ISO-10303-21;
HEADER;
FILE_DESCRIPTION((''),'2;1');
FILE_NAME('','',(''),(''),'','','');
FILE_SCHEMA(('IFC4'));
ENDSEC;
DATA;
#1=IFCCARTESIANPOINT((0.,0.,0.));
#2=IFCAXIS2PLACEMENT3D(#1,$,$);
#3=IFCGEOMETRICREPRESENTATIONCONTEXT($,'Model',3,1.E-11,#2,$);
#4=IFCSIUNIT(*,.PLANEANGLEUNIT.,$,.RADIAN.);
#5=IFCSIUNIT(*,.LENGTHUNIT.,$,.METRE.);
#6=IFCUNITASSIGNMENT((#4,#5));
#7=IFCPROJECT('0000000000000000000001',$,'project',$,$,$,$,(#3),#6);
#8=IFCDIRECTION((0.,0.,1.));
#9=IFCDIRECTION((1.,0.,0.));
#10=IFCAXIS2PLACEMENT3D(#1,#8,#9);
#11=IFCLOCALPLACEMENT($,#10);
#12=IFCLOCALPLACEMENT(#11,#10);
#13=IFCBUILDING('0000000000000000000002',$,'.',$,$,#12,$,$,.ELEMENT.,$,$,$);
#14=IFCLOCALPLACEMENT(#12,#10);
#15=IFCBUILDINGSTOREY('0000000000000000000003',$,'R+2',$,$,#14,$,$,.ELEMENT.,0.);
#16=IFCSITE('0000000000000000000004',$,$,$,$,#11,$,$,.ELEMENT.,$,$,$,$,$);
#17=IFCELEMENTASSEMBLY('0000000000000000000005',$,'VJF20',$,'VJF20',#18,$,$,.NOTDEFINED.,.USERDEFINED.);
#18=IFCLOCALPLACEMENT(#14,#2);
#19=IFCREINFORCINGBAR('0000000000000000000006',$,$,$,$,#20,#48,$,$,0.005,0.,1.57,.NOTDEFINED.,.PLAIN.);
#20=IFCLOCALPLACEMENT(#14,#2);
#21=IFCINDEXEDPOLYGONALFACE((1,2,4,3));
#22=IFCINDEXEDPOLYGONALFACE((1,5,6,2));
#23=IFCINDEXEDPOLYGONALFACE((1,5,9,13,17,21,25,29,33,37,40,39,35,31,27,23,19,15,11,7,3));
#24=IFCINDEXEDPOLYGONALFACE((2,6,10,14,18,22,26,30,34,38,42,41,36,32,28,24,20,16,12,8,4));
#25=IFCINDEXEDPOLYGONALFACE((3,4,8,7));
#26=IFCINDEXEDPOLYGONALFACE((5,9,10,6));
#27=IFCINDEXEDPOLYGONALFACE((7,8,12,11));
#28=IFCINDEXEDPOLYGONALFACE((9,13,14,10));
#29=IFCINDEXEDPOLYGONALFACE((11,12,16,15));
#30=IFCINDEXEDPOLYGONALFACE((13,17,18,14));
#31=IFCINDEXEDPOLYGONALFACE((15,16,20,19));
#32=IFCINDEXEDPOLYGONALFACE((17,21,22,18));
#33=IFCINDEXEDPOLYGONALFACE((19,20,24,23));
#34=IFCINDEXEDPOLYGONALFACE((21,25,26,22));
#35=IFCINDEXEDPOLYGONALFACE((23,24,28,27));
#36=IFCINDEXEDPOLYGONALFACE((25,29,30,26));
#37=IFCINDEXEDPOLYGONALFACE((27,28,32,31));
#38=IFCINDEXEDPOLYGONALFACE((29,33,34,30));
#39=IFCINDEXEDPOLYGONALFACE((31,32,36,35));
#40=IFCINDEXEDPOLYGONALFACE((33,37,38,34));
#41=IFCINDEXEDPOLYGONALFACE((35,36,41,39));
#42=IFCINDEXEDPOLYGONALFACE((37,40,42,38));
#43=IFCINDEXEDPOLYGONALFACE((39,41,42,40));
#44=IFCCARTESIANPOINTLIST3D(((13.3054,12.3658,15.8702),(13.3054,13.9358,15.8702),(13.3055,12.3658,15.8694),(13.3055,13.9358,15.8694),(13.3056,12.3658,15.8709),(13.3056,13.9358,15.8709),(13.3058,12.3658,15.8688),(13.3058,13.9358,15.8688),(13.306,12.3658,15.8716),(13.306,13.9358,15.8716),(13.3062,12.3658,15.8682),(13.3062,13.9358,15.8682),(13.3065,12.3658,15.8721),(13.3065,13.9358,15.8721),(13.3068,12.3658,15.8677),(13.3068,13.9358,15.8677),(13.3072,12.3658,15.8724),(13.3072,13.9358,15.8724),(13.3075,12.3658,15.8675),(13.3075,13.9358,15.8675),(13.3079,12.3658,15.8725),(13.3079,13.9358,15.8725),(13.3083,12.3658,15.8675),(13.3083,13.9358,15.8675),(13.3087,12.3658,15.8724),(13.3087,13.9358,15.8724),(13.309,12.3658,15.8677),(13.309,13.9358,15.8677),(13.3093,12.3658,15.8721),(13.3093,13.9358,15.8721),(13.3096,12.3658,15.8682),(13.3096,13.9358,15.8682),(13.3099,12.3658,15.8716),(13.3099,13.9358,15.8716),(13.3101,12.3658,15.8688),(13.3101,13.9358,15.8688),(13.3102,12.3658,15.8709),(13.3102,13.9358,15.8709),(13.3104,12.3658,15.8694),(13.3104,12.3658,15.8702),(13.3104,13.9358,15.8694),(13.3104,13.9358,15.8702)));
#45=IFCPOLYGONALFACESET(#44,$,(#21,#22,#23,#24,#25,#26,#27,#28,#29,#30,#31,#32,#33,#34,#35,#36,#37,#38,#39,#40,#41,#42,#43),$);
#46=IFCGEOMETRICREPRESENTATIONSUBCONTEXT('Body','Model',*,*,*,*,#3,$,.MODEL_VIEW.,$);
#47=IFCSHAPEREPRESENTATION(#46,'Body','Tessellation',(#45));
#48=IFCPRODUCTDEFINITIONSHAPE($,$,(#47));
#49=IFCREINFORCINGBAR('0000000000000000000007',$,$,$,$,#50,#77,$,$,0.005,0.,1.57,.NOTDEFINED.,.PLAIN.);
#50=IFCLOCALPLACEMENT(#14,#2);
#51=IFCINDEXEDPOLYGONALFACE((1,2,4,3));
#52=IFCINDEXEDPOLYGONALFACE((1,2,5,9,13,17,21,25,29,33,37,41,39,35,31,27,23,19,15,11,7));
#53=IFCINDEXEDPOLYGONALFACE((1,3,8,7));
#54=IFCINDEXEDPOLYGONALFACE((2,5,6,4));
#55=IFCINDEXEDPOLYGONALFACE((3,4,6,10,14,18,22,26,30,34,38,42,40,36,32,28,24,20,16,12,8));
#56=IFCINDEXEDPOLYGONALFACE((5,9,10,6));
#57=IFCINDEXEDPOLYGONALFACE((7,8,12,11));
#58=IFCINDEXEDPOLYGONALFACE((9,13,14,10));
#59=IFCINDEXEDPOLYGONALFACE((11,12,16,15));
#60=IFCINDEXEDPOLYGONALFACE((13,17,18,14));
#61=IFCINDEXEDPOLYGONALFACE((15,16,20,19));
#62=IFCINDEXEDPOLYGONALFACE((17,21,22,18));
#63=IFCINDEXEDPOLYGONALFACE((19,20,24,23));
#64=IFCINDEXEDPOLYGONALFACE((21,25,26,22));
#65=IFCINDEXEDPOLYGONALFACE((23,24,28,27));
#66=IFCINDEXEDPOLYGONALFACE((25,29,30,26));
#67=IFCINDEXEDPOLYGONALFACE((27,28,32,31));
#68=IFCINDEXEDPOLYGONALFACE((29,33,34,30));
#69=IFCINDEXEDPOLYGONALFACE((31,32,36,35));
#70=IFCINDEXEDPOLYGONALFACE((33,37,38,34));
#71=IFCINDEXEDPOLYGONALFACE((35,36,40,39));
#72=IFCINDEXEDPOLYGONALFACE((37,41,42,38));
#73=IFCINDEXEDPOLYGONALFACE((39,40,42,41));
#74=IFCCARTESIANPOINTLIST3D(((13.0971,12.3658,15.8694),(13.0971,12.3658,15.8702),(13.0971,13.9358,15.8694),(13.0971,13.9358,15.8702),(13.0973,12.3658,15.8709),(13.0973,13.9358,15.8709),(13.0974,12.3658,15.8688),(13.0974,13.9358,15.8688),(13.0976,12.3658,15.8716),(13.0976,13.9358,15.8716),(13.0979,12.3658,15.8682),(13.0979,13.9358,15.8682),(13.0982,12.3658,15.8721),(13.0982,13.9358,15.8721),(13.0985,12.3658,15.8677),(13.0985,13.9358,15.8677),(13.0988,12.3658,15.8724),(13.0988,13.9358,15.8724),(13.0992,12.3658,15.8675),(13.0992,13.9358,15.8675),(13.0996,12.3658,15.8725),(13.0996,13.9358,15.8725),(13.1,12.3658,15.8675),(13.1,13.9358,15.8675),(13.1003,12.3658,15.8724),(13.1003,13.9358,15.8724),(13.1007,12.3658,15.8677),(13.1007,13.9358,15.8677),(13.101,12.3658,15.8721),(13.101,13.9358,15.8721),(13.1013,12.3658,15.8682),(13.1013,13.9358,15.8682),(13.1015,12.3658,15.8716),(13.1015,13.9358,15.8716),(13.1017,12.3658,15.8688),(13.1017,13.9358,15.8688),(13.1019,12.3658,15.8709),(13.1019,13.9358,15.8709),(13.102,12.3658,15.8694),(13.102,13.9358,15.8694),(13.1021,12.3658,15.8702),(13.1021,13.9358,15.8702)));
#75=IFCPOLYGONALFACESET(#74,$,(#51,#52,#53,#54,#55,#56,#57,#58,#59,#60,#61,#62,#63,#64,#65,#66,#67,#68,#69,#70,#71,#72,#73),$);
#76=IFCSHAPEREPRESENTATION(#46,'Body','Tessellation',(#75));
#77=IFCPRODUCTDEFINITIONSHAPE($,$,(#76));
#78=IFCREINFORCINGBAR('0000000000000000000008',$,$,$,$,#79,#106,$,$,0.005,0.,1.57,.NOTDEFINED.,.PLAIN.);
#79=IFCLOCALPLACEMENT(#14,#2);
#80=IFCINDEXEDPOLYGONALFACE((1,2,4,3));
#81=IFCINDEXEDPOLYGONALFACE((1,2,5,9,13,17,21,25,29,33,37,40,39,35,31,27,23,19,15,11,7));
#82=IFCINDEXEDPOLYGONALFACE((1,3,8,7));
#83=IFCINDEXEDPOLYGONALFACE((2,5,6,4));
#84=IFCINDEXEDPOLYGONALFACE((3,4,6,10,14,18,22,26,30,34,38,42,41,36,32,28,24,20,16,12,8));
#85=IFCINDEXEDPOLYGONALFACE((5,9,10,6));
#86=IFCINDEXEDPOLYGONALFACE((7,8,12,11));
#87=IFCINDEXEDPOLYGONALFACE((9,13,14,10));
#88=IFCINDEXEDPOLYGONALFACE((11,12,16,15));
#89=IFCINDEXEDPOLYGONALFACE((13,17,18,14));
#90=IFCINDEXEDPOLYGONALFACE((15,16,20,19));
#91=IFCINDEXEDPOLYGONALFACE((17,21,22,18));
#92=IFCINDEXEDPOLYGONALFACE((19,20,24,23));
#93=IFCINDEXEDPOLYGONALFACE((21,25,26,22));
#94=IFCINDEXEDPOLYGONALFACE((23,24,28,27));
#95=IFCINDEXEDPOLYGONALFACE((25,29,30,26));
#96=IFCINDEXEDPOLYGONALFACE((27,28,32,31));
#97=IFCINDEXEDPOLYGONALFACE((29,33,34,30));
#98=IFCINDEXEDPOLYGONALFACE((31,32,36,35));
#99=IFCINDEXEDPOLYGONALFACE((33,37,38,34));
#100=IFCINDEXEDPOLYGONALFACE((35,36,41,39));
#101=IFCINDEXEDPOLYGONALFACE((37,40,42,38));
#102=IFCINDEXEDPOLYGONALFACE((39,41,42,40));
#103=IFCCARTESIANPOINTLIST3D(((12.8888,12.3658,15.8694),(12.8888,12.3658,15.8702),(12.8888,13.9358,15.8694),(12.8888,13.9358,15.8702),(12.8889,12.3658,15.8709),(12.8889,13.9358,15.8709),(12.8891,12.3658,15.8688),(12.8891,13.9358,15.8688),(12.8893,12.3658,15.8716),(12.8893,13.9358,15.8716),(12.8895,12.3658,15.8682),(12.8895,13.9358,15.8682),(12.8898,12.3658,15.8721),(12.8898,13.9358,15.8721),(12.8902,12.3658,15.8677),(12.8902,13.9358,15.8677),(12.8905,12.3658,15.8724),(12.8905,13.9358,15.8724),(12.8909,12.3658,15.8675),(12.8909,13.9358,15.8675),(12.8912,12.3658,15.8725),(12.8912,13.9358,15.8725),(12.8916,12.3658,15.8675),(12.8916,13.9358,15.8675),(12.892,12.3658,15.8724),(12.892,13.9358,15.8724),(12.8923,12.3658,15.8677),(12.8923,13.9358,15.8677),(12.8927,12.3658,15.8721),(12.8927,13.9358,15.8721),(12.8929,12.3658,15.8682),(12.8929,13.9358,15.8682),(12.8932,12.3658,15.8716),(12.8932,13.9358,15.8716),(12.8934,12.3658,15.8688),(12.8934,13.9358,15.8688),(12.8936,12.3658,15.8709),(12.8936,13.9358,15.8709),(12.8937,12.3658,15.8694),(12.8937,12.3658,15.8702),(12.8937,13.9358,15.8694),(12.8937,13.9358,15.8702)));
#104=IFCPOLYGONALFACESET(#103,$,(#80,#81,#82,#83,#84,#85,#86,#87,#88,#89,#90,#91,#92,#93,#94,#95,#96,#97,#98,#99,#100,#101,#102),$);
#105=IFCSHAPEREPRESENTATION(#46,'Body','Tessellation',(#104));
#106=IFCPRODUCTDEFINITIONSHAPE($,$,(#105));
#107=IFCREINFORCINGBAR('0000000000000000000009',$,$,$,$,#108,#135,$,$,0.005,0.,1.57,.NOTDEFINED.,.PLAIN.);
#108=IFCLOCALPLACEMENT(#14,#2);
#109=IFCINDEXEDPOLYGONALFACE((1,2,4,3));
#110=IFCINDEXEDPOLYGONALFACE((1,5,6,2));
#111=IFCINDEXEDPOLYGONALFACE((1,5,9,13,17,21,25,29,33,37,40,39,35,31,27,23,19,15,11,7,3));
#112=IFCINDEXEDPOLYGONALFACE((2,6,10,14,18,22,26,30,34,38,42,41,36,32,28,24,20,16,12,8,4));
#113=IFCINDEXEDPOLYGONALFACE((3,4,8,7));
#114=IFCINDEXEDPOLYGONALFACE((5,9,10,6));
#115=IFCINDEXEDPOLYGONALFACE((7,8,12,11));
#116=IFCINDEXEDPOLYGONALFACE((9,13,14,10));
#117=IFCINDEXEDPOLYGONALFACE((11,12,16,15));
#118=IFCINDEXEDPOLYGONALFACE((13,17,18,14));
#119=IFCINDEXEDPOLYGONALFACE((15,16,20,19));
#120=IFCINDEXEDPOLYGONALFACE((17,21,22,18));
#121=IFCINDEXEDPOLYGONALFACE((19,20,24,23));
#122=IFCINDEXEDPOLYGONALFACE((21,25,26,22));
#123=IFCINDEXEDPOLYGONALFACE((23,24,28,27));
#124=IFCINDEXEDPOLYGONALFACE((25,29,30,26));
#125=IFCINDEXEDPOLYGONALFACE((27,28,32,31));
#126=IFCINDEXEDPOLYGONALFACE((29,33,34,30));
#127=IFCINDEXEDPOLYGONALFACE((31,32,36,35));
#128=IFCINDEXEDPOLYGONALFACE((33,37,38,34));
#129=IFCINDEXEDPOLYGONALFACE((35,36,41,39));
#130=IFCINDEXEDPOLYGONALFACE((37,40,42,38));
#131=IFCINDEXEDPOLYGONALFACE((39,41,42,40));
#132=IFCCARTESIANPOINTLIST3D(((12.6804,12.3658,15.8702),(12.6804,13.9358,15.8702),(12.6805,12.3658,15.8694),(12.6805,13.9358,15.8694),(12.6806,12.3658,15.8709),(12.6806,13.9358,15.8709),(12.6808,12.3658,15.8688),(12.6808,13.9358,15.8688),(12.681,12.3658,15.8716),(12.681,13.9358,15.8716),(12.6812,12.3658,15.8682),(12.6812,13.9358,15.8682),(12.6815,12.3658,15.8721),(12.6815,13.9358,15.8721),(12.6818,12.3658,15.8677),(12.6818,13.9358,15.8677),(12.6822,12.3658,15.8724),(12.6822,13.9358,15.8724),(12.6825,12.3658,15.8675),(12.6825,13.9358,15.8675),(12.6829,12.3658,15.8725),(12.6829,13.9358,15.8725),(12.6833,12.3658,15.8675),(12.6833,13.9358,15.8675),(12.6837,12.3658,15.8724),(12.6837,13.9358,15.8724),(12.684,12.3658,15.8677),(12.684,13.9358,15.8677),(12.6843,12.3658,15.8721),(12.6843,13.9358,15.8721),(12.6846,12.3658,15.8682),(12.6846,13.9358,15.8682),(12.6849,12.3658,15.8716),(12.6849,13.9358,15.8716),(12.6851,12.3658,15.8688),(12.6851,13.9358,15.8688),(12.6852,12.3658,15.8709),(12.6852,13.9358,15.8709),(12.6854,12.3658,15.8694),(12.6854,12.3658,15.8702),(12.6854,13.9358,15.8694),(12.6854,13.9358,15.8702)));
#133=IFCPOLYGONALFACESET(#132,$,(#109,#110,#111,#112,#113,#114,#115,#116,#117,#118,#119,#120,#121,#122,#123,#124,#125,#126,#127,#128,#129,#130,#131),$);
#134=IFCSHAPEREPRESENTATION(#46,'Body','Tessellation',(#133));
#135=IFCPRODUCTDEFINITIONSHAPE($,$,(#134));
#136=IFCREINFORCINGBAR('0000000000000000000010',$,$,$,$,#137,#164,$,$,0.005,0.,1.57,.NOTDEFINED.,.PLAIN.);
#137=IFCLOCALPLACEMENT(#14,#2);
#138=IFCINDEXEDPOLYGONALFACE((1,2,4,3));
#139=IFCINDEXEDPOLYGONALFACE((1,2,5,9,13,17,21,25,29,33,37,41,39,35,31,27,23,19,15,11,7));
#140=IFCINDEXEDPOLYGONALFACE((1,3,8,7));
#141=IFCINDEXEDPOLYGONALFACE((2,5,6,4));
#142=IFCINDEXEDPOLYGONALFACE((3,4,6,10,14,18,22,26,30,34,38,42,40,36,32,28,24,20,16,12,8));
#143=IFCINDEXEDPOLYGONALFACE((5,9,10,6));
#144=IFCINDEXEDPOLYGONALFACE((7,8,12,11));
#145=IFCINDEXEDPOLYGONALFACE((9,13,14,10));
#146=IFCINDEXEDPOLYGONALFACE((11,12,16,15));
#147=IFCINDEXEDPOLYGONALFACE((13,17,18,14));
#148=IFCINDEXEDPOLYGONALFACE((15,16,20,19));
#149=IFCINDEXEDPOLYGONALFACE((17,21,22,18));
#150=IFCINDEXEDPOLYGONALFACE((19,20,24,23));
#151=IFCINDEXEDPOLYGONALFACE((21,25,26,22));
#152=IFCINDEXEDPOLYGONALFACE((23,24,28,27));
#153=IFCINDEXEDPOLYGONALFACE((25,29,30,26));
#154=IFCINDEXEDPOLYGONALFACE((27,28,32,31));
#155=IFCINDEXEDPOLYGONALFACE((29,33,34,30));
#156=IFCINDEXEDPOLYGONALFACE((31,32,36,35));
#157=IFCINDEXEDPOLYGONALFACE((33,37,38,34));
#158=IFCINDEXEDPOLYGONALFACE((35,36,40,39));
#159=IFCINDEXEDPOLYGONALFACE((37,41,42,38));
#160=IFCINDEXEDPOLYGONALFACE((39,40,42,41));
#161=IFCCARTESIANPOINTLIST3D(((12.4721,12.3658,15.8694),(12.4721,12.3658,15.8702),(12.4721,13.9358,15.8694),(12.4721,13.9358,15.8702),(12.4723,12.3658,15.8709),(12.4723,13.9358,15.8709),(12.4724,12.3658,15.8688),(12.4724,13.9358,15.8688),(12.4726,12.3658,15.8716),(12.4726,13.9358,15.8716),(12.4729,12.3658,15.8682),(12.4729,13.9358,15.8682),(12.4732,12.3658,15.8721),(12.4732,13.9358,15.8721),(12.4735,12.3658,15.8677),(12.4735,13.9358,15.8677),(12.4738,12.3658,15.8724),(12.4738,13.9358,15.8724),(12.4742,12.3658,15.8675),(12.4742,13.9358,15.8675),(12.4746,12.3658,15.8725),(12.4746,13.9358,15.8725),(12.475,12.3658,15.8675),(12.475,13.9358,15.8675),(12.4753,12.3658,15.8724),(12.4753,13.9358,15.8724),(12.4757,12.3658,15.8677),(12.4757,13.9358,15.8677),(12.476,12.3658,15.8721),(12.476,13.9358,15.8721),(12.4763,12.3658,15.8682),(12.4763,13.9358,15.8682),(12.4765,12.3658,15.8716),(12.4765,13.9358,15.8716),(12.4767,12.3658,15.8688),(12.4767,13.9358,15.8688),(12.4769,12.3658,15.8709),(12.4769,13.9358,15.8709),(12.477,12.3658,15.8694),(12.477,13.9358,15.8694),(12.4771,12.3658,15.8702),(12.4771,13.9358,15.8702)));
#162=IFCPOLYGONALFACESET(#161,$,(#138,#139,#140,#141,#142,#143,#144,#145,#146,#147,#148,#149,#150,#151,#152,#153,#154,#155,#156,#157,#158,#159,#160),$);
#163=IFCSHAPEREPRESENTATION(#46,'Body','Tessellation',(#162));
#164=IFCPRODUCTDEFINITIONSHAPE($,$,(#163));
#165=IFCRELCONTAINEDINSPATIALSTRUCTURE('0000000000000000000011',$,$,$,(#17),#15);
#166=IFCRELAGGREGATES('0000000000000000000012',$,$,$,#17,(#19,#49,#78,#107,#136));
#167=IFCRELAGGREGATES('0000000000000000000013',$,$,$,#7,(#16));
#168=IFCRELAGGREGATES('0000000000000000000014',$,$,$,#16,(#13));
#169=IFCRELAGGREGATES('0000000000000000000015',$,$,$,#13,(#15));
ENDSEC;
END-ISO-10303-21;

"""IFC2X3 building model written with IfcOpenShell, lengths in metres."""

from ifc_helpers import new_model, entity, si_unit, origin, origin_with_axes, place, context, subcontext, project, spatial, shape, element, aggregate, save


model = new_model("IFC2X3")

# Units and contexts
model_context = context("Model", 3, precision=1e-11, world=origin())
body_context = subcontext(model_context, "Body", "Model", "MODEL_VIEW")
ifc_project = project(units=[si_unit("PLANEANGLEUNIT", "RADIAN"), si_unit("LENGTHUNIT", "METRE")], contexts=[model_context])

# Site, building, storey
site_placement = place(None, origin_with_axes())
site = spatial("IfcSite", under=ifc_project, at=site_placement, CompositionType="ELEMENT")
building_placement = place(site_placement, origin_with_axes())
building = spatial("IfcBuilding", under=site, at=building_placement, Name=".", CompositionType="ELEMENT")
storey_placement = place(building_placement, origin_with_axes())
storey = spatial("IfcBuildingStorey", under=building, at=storey_placement, Name="R+2", CompositionType="ELEMENT", Elevation=0.0)

# Element assembly, reinforcing bars
assembly_1_placement = place(storey_placement, origin_with_axes())
assembly_1 = element("IfcElementAssembly", 1, at=assembly_1_placement, inside=storey, Name="VJF20", ObjectType="VJF20", AssemblyPlace="NOTDEFINED", PredefinedType="USERDEFINED")
reinforcing_bar_1_placement = place(assembly_1_placement, origin_with_axes())
reinforcing_bar_1 = element("IfcReinforcingBar", 2, at=reinforcing_bar_1_placement, BarLength=1.57, BarRole="NOTDEFINED", BarSurface="PLAIN", CrossSectionArea=0.0, NominalDiameter=0.005, shapes=[
    shape(body_context, "Body", "AdvancedSweptSolid", [entity("IfcSweptDiskSolid", entity("IfcPolyline", [entity("IfcCartesianPoint", [13.3079, 12.3658, 15.87]), entity("IfcCartesianPoint", [13.3079, 13.9358, 15.87])]), 0.0025, None, 0.0, 1.57)]),
    shape(body_context, "Body", "AdvancedSweptSolid", [entity("IfcSweptDiskSolid", entity("IfcPolyline", [entity("IfcCartesianPoint", [13.3079, 12.3658, 15.87]), entity("IfcCartesianPoint", [13.3079, 13.9358, 15.87])]), 0.0025, None, 0.0, 1.57)]),
])
reinforcing_bar_2_placement = place(assembly_1_placement, origin_with_axes())
reinforcing_bar_2 = element("IfcReinforcingBar", 3, at=reinforcing_bar_2_placement, BarLength=1.57, BarRole="NOTDEFINED", BarSurface="PLAIN", CrossSectionArea=0.0, NominalDiameter=0.005, shapes=[
    shape(body_context, "Body", "AdvancedSweptSolid", [entity("IfcSweptDiskSolid", entity("IfcPolyline", [entity("IfcCartesianPoint", [13.0996, 12.3658, 15.87]), entity("IfcCartesianPoint", [13.0996, 13.9358, 15.87])]), 0.0025, None, 0.0, 1.57)]),
    shape(body_context, "Body", "AdvancedSweptSolid", [entity("IfcSweptDiskSolid", entity("IfcPolyline", [entity("IfcCartesianPoint", [13.0996, 12.3658, 15.87]), entity("IfcCartesianPoint", [13.0996, 13.9358, 15.87])]), 0.0025, None, 0.0, 1.57)]),
])
reinforcing_bar_3_placement = place(assembly_1_placement, origin_with_axes())
reinforcing_bar_3 = element("IfcReinforcingBar", 4, at=reinforcing_bar_3_placement, BarLength=1.57, BarRole="NOTDEFINED", BarSurface="PLAIN", CrossSectionArea=0.0, NominalDiameter=0.005, shapes=[
    shape(body_context, "Body", "AdvancedSweptSolid", [entity("IfcSweptDiskSolid", entity("IfcPolyline", [entity("IfcCartesianPoint", [12.8912, 12.3658, 15.87]), entity("IfcCartesianPoint", [12.8912, 13.9358, 15.87])]), 0.0025, None, 0.0, 1.57)]),
    shape(body_context, "Body", "AdvancedSweptSolid", [entity("IfcSweptDiskSolid", entity("IfcPolyline", [entity("IfcCartesianPoint", [12.8912, 12.3658, 15.87]), entity("IfcCartesianPoint", [12.8912, 13.9358, 15.87])]), 0.0025, None, 0.0, 1.57)]),
])
reinforcing_bar_4_placement = place(assembly_1_placement, origin_with_axes())
reinforcing_bar_4 = element("IfcReinforcingBar", 5, at=reinforcing_bar_4_placement, BarLength=1.57, BarRole="NOTDEFINED", BarSurface="PLAIN", CrossSectionArea=0.0, NominalDiameter=0.005, shapes=[
    shape(body_context, "Body", "AdvancedSweptSolid", [entity("IfcSweptDiskSolid", entity("IfcPolyline", [entity("IfcCartesianPoint", [12.6829, 12.3658, 15.87]), entity("IfcCartesianPoint", [12.6829, 13.9358, 15.87])]), 0.0025, None, 0.0, 1.57)]),
    shape(body_context, "Body", "AdvancedSweptSolid", [entity("IfcSweptDiskSolid", entity("IfcPolyline", [entity("IfcCartesianPoint", [12.6829, 12.3658, 15.87]), entity("IfcCartesianPoint", [12.6829, 13.9358, 15.87])]), 0.0025, None, 0.0, 1.57)]),
])
reinforcing_bar_5_placement = place(assembly_1_placement, origin_with_axes())
reinforcing_bar_5 = element("IfcReinforcingBar", 6, at=reinforcing_bar_5_placement, BarLength=1.57, BarRole="NOTDEFINED", BarSurface="PLAIN", CrossSectionArea=0.0, NominalDiameter=0.005, shapes=[
    shape(body_context, "Body", "AdvancedSweptSolid", [entity("IfcSweptDiskSolid", entity("IfcPolyline", [entity("IfcCartesianPoint", [12.4746, 12.3658, 15.87]), entity("IfcCartesianPoint", [12.4746, 13.9358, 15.87])]), 0.0025, None, 0.0, 1.57)]),
    shape(body_context, "Body", "AdvancedSweptSolid", [entity("IfcSweptDiskSolid", entity("IfcPolyline", [entity("IfcCartesianPoint", [12.4746, 12.3658, 15.87]), entity("IfcCartesianPoint", [12.4746, 13.9358, 15.87])]), 0.0025, None, 0.0, 1.57)]),
])
aggregate(assembly_1, [reinforcing_bar_1, reinforcing_bar_2, reinforcing_bar_3, reinforcing_bar_4, reinforcing_bar_5])

save(model, "model.ifc")
